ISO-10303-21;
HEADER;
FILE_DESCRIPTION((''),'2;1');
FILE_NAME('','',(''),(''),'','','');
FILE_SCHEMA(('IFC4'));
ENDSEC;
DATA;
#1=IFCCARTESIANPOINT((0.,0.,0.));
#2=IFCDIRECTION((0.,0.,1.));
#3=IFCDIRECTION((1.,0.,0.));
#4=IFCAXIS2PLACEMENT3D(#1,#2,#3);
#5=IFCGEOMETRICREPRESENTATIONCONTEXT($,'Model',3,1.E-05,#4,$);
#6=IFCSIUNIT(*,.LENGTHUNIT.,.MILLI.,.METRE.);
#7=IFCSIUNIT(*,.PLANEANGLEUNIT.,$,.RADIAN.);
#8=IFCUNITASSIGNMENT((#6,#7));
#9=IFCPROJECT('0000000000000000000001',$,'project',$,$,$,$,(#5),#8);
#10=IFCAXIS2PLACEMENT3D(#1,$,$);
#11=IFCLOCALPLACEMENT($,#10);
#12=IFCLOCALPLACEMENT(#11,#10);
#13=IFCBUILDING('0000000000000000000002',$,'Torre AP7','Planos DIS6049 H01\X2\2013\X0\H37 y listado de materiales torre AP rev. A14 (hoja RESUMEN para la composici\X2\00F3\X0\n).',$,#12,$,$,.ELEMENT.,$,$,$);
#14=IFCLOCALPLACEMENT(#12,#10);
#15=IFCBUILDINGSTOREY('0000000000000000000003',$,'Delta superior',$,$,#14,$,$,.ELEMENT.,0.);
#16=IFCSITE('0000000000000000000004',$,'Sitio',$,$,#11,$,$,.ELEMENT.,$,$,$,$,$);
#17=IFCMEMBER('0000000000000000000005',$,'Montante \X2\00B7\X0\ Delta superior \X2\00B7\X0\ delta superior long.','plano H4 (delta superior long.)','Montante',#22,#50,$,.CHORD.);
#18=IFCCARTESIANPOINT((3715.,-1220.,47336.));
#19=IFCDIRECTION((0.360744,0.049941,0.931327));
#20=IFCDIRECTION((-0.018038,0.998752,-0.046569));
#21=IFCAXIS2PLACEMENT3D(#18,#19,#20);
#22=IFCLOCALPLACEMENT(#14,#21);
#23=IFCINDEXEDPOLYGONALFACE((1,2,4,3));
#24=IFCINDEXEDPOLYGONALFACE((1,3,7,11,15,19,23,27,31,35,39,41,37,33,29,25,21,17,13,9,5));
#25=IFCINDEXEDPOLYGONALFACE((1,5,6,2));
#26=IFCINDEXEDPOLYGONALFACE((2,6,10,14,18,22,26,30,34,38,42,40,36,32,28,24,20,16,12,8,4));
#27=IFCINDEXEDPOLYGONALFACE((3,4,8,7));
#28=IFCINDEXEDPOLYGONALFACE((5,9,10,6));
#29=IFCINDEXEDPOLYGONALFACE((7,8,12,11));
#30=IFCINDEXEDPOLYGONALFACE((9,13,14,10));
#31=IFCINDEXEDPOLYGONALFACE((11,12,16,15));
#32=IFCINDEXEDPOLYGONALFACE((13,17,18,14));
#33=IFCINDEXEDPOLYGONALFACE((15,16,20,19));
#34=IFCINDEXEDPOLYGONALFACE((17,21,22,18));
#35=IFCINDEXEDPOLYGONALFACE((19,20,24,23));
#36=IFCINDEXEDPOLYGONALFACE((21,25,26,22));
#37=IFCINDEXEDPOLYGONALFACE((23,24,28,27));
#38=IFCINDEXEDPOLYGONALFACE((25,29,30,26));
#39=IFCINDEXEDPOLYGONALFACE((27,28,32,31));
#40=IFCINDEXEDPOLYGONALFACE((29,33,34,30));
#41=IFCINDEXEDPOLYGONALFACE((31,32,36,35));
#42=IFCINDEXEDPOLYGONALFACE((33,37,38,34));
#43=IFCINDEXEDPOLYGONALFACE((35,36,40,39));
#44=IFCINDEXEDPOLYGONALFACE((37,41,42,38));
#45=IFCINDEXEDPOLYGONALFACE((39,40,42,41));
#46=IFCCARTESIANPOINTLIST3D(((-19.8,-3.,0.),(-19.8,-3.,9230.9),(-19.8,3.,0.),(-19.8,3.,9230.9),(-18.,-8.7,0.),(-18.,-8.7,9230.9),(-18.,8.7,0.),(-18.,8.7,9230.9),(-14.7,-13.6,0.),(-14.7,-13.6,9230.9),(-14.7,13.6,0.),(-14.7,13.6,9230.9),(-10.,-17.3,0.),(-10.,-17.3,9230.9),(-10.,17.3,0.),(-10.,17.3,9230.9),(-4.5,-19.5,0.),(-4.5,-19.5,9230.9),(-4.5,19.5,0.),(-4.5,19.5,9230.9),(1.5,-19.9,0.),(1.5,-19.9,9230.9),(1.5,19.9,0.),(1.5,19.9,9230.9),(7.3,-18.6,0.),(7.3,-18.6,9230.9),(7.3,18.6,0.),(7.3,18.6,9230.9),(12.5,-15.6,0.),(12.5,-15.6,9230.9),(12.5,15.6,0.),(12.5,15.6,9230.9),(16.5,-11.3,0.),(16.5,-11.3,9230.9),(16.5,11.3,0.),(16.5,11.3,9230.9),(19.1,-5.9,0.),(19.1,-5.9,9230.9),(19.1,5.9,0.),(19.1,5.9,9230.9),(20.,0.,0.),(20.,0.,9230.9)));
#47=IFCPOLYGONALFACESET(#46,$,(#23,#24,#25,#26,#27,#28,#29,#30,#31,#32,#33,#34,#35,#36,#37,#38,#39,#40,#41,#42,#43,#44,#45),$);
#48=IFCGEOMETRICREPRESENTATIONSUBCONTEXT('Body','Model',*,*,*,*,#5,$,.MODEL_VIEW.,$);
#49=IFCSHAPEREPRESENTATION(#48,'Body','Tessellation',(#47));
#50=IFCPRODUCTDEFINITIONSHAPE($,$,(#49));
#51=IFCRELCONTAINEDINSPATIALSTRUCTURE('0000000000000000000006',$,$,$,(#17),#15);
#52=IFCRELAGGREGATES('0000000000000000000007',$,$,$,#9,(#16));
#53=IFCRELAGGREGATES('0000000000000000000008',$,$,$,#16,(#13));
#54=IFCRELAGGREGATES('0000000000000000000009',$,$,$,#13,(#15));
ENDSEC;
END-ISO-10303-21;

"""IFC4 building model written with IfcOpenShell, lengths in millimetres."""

from ifc_helpers import new_model, si_unit, frame, origin, origin_with_axes, place, context, subcontext, project, spatial, circle, extrude, element, save


model = new_model("IFC4")

# Units and contexts
model_context = context("Model", 3, precision=1e-05, world=origin_with_axes())
body_context = subcontext(model_context, "Body", "Model", "MODEL_VIEW")
ifc_project = project(units=[si_unit("LENGTHUNIT", "METRE", prefix="MILLI"), si_unit("PLANEANGLEUNIT", "RADIAN")], contexts=[model_context])

# Site, building, storey
site_placement = place(None, origin())
site = spatial("IfcSite", under=ifc_project, at=site_placement, Name="Sitio", CompositionType="ELEMENT")
building_placement = place(site_placement, origin())
building = spatial("IfcBuilding", under=site, at=building_placement, Name="Torre AP7", Description="Planos DIS6049 H01–H37 y listado de materiales torre AP rev. A14 (hoja RESUMEN para la composición).", CompositionType="ELEMENT")
storey_placement = place(building_placement, origin())
storey = spatial("IfcBuildingStorey", under=building, at=storey_placement, Name="Delta superior", CompositionType="ELEMENT", Elevation=0.0)

# Member
for number, where, z_axis, x_axis, name in (
    (1, (3715.0, -1220.0, 47336.0), (0.360744, 0.049941, 0.931327), (-0.018038, 0.998752, -0.046569), "Montante · Delta superior · delta superior long."),
):
    element("IfcMember", number, at=place(storey_placement, frame(where, z_axis=z_axis, x_axis=x_axis)), inside=storey, Name=name, Description="plano H4 (delta superior long.)", ObjectType="Montante", PredefinedType="CHORD", context=body_context, shape_type="SweptSolid", body=[
        extrude(circle(Radius=20.0), None, (0.0, 0.0, 1.0), 9230.9),
    ])

save(model, "model.ifc")
